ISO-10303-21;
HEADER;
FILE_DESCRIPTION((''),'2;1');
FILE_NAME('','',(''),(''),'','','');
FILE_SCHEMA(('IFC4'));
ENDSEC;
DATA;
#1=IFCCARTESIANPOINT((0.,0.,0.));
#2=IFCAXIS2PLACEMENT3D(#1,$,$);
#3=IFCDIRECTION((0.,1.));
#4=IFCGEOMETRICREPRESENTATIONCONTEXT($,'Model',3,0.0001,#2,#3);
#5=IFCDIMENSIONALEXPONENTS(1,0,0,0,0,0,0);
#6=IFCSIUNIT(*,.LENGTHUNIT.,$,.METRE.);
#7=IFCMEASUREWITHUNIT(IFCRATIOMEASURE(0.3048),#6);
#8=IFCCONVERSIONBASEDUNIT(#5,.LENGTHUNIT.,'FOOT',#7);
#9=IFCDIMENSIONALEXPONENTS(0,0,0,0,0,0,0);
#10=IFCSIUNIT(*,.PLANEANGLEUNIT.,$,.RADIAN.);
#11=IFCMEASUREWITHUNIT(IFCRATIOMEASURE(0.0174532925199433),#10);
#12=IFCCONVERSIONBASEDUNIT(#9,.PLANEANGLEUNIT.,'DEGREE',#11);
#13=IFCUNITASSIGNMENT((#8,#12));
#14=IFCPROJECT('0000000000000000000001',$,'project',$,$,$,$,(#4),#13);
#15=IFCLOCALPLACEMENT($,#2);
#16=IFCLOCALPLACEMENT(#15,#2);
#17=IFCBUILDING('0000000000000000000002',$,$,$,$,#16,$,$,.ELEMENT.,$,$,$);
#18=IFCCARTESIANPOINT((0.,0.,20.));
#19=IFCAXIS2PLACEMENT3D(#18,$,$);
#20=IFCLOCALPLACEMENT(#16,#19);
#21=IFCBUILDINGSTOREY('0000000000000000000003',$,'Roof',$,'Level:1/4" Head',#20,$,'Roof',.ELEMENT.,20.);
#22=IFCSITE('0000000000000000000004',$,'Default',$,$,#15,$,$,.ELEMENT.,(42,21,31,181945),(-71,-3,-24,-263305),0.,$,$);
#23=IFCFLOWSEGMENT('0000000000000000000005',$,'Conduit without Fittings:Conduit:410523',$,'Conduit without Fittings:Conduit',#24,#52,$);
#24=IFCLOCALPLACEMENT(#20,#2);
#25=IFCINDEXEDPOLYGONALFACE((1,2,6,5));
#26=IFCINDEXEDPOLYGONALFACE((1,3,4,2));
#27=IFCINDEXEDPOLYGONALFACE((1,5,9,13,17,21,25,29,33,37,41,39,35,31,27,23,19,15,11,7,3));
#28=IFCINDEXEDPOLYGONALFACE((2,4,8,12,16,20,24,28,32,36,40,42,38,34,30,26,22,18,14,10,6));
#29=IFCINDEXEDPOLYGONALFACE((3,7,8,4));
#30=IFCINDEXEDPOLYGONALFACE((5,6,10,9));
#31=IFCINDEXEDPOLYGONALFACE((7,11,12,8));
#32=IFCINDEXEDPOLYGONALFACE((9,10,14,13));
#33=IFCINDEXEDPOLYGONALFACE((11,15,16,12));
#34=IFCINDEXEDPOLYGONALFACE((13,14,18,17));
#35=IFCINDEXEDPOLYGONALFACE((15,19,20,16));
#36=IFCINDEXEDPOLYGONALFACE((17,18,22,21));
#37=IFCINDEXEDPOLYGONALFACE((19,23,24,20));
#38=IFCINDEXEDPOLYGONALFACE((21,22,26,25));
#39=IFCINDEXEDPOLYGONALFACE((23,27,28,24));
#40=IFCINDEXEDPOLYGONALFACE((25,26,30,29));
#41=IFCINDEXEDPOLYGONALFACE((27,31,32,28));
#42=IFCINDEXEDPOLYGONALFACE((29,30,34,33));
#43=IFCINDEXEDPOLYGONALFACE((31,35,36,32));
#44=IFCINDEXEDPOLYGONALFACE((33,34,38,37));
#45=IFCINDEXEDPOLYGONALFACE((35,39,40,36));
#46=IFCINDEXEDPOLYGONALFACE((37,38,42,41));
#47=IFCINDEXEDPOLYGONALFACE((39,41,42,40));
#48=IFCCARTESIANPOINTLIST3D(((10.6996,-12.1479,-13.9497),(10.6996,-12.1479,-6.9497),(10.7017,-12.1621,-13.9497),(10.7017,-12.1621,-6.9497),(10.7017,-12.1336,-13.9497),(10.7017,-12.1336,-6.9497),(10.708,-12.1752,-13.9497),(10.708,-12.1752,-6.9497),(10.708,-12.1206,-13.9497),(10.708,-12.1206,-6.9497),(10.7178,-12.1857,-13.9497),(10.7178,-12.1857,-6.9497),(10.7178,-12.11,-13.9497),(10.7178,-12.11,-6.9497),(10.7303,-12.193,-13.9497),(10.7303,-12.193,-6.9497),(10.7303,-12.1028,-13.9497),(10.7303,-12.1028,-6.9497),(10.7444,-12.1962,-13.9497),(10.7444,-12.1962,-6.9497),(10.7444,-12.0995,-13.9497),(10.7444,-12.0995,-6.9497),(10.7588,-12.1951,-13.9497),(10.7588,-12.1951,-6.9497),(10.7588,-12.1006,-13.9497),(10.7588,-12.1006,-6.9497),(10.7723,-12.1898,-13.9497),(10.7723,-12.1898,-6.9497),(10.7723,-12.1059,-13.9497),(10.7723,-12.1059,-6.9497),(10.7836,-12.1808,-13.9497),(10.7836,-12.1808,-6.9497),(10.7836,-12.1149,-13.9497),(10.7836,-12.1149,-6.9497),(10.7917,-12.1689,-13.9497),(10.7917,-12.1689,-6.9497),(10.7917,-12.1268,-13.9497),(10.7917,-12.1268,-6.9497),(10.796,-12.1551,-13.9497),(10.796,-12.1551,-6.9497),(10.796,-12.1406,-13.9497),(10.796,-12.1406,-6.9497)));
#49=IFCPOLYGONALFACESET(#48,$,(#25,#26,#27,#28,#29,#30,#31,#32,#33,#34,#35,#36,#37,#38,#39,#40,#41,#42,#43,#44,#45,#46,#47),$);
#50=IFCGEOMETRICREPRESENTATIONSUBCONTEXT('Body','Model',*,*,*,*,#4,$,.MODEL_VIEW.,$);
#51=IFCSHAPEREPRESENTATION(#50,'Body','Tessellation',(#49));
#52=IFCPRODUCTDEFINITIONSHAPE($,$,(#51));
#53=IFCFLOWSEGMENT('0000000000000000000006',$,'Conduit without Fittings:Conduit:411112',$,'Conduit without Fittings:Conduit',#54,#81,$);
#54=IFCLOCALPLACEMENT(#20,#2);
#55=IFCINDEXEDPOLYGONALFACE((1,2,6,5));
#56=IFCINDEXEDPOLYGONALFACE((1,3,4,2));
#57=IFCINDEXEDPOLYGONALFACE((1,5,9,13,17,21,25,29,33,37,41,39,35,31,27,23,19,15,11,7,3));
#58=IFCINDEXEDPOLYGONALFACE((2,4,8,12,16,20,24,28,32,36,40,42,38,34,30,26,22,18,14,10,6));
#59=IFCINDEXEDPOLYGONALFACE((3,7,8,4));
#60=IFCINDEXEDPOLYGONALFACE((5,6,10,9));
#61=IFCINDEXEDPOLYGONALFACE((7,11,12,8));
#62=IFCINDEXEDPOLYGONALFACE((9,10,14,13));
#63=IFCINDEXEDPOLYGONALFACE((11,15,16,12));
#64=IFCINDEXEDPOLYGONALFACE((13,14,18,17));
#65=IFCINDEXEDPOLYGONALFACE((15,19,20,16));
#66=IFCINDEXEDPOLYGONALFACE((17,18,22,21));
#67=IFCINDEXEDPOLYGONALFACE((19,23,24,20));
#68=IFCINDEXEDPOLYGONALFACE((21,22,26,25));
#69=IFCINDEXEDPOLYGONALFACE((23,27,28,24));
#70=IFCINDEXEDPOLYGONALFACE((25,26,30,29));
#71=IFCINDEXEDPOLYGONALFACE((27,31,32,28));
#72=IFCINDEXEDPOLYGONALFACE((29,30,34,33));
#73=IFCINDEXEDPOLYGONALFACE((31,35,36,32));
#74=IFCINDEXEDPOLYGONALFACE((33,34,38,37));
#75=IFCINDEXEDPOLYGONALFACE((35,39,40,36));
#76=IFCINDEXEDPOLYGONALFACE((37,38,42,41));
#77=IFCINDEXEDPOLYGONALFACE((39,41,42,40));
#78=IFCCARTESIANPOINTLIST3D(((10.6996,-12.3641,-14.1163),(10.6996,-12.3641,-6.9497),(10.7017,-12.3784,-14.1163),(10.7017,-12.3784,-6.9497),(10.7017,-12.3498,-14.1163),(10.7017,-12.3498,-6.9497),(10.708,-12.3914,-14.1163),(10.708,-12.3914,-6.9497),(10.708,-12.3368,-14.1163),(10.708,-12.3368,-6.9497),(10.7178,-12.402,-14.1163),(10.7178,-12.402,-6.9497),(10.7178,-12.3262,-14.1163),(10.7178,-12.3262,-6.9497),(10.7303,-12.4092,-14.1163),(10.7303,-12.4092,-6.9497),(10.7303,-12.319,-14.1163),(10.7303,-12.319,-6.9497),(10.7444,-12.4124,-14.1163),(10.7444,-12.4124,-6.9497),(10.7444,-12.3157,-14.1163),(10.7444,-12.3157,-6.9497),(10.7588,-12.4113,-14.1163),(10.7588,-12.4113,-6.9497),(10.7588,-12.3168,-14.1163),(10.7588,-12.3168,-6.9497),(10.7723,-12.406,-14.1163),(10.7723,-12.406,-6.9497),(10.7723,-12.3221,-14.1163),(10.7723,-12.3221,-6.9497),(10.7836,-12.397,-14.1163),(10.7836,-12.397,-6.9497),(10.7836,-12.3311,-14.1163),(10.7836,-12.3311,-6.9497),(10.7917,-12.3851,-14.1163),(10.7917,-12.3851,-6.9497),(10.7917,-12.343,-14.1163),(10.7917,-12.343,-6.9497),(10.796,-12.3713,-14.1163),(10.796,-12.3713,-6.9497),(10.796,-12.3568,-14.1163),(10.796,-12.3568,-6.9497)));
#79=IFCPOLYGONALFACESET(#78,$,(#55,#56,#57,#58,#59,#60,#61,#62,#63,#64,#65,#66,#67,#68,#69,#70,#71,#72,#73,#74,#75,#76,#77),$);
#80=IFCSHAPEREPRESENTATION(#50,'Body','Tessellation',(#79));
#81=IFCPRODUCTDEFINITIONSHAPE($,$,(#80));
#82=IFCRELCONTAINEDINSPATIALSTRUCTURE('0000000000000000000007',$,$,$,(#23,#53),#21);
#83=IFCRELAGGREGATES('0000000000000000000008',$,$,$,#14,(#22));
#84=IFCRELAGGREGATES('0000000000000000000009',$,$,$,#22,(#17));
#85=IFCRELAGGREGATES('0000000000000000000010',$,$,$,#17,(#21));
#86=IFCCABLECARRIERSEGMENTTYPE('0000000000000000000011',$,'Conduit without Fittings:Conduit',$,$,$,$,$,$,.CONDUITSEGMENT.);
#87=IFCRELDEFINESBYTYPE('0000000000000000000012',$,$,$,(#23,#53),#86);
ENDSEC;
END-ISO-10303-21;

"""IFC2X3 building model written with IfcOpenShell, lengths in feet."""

from ifc_helpers import new_model, entity, si_unit, converted_unit, direction, frame, origin, origin_2d_with_axis, place, context, subcontext, project, spatial, circle, extrude, type_object, element, save


model = new_model("IFC2X3")

# Units and contexts
model_context = context("Model", 3, precision=0.0001, world=origin(), true_north=direction((0.0, 1.0)))
body_context = subcontext(model_context, "Body", "Model", "MODEL_VIEW")
ifc_project = project(units=[converted_unit("LENGTHUNIT", "FOOT", entity("IfcRatioMeasure", 0.3048), si_unit("LENGTHUNIT", "METRE"), dimensions=[1, 0, 0, 0, 0, 0, 0]), converted_unit("PLANEANGLEUNIT", "DEGREE", entity("IfcRatioMeasure", 0.0174532925199433), si_unit("PLANEANGLEUNIT", "RADIAN"), dimensions=[0, 0, 0, 0, 0, 0, 0])], contexts=[model_context])

# Site, building, storey
site_placement = place(None, origin())
site = spatial("IfcSite", under=ifc_project, at=site_placement, Name="Default", CompositionType="ELEMENT", RefLatitude=(42, 21, 31, 181945), RefLongitude=(-71, -3, -24, -263305), RefElevation=0.0)
building_placement = place(site_placement, origin())
building = spatial("IfcBuilding", under=site, at=building_placement, CompositionType="ELEMENT")
storey_placement = place(building_placement, frame((0.0, 0.0, 20.0)))
storey = spatial("IfcBuildingStorey", under=building, at=storey_placement, Name="Roof", ObjectType="Level:1/4\" Head", LongName="Roof", CompositionType="ELEMENT", Elevation=20.0)

# Flow segments
cable_carrier_segment_type_1 = type_object("IfcCableCarrierSegmentType", Name="Conduit without Fittings:Conduit", PredefinedType="CONDUITSEGMENT")
flow_segment_1_placement = place(storey_placement, origin())
element("IfcFlowSegment", 1, at=flow_segment_1_placement, inside=storey, type_object=cable_carrier_segment_type_1, Name="Conduit without Fittings:Conduit:410523", ObjectType="Conduit without Fittings:Conduit", context=body_context, shape_type="SweptSolid", body=[
    extrude(circle(Radius=0.0485, at=origin_2d_with_axis()), frame((10.748, -12.1479, -13.9497), z_axis=(0.0, 0.0, 1.0), x_axis=(-1.0, 0.0, 0.0)), (0.0, 0.0, 1.0), 7.0),
])
flow_segment_2_placement = place(storey_placement, origin())
element("IfcFlowSegment", 2, at=flow_segment_2_placement, inside=storey, type_object=cable_carrier_segment_type_1, Name="Conduit without Fittings:Conduit:411112", ObjectType="Conduit without Fittings:Conduit", context=body_context, shape_type="SweptSolid", body=[
    extrude(circle(Radius=0.0485, at=origin_2d_with_axis()), frame((10.748, -12.3641, -14.1163), z_axis=(0.0, 0.0, 1.0), x_axis=(-1.0, 0.0, 0.0)), (0.0, 0.0, 1.0), 7.1667),
])

save(model, "model.ifc")
